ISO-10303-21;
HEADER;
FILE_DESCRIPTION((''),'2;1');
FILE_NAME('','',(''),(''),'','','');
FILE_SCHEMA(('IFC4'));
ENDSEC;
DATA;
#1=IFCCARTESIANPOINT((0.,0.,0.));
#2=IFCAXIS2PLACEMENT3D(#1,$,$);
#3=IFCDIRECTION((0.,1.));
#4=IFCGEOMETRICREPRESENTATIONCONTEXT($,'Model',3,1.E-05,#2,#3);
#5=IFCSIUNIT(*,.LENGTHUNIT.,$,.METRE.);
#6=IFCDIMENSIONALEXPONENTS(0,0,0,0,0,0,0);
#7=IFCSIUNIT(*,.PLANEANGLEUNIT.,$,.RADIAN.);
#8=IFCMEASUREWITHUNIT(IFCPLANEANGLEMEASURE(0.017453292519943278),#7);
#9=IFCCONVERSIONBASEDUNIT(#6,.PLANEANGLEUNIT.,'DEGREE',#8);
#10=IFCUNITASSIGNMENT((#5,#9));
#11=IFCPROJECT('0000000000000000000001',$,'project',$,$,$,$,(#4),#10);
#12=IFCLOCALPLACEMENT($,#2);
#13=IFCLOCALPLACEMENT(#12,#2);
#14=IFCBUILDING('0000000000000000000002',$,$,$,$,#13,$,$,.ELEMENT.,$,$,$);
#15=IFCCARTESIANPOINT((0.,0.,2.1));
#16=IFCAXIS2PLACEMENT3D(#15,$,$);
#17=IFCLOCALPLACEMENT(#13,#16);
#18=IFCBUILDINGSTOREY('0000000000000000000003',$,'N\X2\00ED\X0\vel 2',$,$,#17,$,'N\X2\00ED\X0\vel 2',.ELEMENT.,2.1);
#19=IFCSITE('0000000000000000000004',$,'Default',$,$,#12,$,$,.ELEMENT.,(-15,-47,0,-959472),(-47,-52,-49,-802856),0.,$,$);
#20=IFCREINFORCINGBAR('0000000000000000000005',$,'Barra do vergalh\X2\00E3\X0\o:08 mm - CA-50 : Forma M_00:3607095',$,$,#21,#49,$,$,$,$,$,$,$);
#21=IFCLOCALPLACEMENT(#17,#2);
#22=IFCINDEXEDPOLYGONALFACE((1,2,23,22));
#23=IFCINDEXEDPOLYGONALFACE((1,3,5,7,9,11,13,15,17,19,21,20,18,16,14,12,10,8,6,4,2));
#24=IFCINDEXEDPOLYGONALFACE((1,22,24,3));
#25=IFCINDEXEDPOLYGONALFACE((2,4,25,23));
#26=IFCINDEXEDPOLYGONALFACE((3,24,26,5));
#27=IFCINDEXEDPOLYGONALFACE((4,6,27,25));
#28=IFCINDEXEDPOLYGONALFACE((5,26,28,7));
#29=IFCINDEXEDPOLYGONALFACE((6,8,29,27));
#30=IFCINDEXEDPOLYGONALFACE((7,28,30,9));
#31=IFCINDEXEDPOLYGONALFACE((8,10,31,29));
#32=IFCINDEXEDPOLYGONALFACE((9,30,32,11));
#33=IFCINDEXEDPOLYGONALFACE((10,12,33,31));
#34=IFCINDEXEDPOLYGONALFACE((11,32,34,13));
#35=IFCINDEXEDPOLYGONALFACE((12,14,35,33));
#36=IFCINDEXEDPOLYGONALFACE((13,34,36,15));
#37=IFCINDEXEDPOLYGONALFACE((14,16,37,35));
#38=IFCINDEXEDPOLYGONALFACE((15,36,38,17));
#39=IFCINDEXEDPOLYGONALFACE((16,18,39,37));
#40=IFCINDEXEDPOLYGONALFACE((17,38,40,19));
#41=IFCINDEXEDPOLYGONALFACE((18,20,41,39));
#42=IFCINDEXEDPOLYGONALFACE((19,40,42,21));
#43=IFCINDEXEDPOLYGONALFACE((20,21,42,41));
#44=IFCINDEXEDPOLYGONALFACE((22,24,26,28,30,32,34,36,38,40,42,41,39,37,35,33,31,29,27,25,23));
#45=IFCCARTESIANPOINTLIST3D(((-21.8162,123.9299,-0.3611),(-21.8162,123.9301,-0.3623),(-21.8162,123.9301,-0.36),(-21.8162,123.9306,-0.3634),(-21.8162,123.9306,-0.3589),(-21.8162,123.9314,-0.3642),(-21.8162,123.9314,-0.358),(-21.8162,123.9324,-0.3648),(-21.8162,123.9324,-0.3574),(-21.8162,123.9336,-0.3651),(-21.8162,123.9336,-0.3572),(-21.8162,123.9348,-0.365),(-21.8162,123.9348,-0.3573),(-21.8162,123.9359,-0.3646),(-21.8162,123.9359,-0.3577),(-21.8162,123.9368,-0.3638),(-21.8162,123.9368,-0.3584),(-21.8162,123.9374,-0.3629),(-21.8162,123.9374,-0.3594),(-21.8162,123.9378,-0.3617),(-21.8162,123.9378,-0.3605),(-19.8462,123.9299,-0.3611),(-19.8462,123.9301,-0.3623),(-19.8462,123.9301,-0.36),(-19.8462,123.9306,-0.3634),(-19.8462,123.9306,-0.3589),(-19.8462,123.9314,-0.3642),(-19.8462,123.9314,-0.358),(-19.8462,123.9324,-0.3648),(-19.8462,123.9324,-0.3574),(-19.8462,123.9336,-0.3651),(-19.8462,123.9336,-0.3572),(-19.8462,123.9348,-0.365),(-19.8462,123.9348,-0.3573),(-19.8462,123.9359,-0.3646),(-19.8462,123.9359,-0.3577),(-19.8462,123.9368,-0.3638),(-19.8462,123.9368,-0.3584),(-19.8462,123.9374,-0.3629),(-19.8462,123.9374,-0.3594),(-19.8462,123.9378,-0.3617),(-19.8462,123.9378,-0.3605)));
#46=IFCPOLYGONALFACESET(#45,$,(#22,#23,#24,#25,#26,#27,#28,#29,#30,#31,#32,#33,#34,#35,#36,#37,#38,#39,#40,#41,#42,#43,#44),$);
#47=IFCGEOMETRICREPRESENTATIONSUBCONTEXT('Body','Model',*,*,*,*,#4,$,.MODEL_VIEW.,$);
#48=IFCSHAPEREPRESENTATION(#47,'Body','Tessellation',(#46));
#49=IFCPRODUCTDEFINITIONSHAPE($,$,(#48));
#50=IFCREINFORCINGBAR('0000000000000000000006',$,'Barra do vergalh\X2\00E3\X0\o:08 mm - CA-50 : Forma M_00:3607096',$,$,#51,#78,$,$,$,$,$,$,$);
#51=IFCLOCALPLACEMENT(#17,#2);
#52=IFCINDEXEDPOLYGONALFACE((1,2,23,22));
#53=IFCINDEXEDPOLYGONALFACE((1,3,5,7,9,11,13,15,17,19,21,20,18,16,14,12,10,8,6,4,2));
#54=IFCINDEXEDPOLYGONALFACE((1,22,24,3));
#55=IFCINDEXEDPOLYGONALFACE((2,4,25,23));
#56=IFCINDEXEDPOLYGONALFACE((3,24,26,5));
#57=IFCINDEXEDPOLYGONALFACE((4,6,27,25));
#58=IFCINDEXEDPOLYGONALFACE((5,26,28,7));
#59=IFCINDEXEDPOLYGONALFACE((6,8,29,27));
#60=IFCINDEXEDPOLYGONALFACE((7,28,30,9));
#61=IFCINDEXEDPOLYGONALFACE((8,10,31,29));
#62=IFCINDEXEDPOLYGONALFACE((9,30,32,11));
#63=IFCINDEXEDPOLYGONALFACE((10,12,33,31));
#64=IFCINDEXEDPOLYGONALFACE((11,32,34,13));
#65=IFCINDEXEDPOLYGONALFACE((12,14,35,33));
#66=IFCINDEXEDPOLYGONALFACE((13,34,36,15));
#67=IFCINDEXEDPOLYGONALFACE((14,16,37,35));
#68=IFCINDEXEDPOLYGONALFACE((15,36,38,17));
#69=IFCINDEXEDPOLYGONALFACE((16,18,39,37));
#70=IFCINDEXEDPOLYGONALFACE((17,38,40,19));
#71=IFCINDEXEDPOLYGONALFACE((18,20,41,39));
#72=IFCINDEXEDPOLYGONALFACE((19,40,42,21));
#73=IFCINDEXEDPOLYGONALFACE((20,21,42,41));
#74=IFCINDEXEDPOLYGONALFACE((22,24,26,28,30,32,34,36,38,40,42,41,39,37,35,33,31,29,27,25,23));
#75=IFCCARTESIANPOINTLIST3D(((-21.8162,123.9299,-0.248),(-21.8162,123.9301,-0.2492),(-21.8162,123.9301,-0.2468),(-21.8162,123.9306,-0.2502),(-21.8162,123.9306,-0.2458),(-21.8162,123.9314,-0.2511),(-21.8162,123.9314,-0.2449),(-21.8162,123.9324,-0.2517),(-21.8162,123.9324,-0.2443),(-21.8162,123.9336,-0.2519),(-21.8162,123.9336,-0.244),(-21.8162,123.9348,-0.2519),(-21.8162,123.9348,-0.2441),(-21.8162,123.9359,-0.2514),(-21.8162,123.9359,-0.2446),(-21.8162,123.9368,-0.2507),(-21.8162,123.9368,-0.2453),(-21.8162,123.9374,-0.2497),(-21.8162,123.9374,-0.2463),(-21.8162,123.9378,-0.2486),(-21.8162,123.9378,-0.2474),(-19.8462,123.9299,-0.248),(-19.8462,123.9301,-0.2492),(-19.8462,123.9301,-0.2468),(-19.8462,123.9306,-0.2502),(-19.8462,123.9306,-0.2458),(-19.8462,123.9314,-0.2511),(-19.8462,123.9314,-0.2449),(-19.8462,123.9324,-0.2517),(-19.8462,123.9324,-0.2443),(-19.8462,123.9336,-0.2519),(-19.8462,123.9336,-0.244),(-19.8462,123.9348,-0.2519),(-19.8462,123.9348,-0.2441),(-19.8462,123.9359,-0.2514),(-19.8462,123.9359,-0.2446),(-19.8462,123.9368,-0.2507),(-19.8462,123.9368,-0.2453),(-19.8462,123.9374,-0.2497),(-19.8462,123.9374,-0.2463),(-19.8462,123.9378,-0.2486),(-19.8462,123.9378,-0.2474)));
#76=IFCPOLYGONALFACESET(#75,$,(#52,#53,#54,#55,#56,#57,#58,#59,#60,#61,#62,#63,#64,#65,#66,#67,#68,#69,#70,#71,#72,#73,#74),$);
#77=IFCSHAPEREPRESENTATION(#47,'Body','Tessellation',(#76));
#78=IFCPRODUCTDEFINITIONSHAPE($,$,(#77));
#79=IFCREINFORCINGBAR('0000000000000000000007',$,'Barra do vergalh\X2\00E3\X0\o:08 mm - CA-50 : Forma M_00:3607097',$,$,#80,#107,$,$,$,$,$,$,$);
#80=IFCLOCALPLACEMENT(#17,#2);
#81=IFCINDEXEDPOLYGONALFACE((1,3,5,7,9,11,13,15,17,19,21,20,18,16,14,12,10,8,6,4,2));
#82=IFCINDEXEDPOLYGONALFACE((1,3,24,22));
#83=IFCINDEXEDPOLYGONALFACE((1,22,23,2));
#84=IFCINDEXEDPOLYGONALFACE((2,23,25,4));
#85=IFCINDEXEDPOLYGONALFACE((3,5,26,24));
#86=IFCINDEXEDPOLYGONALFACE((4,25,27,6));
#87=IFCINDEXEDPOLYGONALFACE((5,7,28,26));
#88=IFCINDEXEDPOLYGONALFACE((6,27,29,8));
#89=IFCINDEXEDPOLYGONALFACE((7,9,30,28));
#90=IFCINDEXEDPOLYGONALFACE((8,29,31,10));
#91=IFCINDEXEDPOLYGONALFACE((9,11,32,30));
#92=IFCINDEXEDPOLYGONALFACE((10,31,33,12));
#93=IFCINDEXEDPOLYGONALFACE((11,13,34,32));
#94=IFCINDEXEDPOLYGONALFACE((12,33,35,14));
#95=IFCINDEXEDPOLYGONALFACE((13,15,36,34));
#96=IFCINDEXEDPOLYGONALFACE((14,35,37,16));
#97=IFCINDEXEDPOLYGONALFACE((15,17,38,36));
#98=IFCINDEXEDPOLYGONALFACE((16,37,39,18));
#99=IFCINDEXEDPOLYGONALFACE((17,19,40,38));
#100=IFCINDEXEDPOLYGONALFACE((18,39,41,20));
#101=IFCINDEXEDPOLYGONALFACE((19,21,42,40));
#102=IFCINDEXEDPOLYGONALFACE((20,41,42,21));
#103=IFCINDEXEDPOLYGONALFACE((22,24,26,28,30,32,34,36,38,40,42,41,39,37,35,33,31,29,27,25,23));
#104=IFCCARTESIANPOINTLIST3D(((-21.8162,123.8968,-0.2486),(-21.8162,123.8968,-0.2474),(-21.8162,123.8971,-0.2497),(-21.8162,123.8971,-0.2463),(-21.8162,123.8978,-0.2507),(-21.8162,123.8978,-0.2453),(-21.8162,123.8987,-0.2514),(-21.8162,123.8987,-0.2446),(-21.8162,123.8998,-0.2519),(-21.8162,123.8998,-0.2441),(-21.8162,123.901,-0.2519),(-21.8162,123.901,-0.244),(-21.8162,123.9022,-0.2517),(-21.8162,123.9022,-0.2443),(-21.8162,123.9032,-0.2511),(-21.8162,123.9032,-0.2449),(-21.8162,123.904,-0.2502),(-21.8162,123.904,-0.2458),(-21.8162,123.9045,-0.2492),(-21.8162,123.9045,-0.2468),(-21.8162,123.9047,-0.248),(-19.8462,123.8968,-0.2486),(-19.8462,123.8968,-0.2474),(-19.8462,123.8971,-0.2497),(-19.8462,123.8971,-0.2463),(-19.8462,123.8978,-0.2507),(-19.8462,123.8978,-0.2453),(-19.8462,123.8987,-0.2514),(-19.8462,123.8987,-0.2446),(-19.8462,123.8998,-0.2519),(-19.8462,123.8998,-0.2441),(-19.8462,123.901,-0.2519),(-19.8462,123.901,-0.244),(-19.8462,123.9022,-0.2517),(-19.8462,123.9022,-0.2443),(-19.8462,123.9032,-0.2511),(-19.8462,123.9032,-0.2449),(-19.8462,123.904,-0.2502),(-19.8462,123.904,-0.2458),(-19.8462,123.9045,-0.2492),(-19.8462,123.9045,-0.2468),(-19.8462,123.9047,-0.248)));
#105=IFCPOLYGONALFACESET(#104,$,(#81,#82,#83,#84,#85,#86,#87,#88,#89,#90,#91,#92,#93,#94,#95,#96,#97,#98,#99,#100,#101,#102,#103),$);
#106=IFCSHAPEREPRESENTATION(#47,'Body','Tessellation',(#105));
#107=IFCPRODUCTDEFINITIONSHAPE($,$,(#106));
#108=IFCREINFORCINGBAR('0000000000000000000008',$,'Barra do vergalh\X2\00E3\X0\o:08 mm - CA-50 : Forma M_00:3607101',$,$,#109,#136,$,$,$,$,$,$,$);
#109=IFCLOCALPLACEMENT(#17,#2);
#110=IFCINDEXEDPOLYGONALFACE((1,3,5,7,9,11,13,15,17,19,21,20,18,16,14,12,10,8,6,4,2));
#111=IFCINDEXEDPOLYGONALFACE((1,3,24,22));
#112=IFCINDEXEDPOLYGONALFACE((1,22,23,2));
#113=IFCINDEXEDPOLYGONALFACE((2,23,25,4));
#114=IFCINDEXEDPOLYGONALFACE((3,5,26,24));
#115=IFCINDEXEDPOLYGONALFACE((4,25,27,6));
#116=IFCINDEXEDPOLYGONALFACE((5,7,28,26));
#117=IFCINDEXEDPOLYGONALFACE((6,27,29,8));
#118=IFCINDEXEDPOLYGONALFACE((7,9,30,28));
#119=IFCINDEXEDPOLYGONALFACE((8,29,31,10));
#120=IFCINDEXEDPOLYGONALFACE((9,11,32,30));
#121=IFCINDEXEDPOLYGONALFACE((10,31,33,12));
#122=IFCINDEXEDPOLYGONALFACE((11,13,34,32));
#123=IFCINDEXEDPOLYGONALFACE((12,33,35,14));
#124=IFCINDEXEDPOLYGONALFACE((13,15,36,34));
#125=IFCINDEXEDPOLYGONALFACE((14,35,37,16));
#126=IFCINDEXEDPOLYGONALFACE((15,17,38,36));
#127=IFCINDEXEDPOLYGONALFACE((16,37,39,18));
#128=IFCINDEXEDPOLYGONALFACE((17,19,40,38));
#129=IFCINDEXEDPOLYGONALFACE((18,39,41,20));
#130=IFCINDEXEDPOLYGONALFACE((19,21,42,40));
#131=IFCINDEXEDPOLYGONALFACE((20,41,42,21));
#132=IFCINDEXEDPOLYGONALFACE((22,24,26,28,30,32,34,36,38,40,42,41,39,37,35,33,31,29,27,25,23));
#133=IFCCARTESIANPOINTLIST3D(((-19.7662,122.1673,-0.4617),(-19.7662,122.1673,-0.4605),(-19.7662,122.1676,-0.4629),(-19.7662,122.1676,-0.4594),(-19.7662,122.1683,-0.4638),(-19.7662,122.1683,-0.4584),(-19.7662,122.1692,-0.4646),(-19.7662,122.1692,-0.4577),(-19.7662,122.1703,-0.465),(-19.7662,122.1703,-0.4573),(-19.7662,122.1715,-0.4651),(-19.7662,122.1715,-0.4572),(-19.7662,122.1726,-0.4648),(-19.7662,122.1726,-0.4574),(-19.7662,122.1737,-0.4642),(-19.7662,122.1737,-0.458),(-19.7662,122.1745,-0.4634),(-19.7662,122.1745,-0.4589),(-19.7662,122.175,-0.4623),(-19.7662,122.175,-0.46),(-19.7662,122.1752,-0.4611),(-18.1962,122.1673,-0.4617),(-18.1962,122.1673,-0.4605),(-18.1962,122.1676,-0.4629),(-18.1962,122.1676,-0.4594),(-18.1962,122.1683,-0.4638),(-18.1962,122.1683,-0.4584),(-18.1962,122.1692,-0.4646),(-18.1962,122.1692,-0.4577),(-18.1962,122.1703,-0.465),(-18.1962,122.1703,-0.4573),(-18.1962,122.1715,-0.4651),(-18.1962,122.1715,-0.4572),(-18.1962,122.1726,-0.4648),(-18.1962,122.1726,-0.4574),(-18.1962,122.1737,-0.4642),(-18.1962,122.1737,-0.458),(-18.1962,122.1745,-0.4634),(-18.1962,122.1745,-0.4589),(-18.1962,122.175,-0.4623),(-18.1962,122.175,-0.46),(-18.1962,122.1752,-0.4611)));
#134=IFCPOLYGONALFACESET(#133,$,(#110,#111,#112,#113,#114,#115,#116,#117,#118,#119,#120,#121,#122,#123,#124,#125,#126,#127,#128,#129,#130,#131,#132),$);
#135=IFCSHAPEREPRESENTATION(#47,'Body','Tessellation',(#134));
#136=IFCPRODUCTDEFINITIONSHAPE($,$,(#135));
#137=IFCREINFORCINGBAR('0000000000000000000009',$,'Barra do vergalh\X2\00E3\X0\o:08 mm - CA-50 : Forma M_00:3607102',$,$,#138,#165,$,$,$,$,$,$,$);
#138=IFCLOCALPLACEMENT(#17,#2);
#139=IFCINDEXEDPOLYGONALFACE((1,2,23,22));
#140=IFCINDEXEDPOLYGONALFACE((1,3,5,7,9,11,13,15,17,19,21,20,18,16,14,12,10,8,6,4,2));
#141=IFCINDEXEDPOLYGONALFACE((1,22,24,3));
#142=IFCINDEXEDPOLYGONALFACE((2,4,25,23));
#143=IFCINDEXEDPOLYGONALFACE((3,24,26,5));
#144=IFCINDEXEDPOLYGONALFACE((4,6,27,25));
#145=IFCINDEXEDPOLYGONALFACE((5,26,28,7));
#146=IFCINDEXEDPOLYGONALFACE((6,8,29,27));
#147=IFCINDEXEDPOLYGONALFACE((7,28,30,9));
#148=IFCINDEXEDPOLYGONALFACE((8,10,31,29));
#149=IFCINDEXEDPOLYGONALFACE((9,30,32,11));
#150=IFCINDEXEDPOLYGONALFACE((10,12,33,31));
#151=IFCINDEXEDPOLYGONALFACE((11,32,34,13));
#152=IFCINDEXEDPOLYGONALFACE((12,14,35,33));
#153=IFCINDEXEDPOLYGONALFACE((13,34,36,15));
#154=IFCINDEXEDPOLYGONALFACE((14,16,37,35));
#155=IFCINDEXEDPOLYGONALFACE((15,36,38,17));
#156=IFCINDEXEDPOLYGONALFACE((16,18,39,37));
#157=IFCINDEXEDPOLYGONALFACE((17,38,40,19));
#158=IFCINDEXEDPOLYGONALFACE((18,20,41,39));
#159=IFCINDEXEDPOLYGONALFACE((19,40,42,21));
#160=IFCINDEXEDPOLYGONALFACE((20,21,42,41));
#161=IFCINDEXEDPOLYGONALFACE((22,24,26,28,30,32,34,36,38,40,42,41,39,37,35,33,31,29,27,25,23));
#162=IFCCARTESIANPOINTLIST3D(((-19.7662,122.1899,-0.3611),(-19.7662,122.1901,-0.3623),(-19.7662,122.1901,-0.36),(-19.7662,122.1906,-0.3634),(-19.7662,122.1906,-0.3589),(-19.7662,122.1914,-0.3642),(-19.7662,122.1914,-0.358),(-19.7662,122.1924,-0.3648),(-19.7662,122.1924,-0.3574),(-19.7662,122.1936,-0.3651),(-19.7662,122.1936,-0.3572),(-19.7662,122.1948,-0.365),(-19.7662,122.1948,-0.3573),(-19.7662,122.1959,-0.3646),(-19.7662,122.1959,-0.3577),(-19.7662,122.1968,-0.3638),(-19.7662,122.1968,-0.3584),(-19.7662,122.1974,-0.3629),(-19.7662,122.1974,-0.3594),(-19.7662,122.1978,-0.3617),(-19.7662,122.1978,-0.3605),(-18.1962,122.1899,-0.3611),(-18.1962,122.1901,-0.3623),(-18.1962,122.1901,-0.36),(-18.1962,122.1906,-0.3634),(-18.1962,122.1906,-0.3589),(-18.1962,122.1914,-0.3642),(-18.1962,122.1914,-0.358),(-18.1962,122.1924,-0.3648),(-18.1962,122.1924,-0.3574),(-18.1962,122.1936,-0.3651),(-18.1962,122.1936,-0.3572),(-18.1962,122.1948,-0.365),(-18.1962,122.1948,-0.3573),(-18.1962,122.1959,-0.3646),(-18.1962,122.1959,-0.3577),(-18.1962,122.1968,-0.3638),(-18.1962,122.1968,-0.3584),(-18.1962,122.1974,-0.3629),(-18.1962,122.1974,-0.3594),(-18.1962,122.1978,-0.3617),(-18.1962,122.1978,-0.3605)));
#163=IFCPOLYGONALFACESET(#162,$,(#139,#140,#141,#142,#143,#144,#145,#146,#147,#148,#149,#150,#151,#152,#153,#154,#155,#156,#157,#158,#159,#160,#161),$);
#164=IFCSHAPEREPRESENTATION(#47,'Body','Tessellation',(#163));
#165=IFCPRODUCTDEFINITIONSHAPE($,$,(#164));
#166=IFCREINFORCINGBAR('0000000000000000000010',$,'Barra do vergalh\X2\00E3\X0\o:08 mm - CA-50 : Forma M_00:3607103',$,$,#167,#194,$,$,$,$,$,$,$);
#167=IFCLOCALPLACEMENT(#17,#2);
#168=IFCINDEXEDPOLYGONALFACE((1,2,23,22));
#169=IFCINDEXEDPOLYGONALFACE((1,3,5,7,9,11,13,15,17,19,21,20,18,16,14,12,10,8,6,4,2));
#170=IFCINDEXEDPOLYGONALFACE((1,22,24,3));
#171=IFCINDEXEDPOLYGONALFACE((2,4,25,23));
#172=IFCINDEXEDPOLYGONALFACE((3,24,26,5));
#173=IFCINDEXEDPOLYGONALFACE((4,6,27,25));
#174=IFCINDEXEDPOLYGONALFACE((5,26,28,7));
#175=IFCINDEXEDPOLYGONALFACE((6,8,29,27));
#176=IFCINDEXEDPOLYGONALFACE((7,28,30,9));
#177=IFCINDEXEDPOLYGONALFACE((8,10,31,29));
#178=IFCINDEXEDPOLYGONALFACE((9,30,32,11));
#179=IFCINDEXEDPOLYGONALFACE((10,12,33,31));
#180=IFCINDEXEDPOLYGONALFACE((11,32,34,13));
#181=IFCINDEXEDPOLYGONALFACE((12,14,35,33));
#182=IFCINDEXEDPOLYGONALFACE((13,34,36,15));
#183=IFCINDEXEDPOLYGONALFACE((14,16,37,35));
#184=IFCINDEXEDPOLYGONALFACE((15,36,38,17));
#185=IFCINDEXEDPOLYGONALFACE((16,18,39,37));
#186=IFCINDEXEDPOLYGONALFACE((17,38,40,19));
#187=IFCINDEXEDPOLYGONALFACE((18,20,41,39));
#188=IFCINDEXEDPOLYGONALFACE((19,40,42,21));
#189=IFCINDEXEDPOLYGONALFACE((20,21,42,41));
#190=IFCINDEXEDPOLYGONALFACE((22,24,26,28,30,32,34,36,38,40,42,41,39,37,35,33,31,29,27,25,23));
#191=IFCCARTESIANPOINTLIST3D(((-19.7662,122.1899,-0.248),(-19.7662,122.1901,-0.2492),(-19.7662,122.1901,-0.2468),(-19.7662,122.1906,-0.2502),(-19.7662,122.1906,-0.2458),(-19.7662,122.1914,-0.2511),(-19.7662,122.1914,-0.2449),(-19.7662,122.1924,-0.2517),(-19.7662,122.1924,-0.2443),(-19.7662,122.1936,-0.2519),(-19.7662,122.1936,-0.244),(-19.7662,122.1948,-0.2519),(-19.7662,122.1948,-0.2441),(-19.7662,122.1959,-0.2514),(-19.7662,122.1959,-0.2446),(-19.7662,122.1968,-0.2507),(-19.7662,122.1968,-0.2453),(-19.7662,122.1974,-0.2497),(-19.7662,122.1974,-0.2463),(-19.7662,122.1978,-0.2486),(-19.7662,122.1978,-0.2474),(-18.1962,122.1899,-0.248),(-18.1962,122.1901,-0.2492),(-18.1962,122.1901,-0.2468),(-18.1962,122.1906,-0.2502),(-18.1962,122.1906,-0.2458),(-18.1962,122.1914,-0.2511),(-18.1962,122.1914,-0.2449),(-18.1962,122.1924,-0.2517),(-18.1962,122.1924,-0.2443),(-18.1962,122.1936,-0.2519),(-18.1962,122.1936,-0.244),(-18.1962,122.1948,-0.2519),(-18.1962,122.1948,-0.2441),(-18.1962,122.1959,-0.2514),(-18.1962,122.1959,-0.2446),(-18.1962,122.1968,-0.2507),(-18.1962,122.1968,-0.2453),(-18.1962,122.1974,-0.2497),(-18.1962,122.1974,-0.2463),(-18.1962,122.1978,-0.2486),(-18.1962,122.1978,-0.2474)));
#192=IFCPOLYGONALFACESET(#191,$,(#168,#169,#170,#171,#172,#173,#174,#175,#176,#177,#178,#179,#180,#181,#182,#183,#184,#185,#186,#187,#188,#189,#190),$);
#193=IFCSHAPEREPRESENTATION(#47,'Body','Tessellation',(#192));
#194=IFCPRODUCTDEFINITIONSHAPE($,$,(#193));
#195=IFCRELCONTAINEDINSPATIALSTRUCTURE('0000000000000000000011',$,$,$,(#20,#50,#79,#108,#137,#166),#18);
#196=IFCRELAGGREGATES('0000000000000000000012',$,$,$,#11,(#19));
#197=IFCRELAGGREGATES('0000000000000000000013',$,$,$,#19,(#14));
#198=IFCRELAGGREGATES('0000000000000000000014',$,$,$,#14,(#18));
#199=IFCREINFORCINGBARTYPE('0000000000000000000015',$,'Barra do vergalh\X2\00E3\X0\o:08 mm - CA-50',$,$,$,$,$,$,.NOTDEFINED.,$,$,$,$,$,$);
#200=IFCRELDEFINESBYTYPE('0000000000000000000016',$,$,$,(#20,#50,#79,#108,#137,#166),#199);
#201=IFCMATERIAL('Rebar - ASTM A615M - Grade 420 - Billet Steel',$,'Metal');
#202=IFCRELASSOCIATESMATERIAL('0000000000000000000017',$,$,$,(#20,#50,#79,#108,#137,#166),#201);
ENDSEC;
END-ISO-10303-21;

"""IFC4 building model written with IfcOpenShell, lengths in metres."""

from ifc_helpers import new_model, entity, si_unit, converted_unit, direction, frame, origin, place, context, subcontext, project, spatial, material, type_object, element, save


model = new_model("IFC4")

# Units and contexts
model_context = context("Model", 3, precision=1e-05, world=origin(), true_north=direction((0.0, 1.0)))
body_context = subcontext(model_context, "Body", "Model", "MODEL_VIEW")
ifc_project = project(units=[si_unit("LENGTHUNIT", "METRE"), converted_unit("PLANEANGLEUNIT", "DEGREE", entity("IfcPlaneAngleMeasure", 0.017453292519943278), si_unit("PLANEANGLEUNIT", "RADIAN"), dimensions=[0, 0, 0, 0, 0, 0, 0])], contexts=[model_context])

# Site, building, storey
site_placement = place(None, origin())
site = spatial("IfcSite", under=ifc_project, at=site_placement, Name="Default", CompositionType="ELEMENT", RefLatitude=(-15, -47, 0, -959472), RefLongitude=(-47, -52, -49, -802856), RefElevation=0.0)
building_placement = place(site_placement, origin())
building = spatial("IfcBuilding", under=site, at=building_placement, CompositionType="ELEMENT")
storey_placement = place(building_placement, frame((0.0, 0.0, 2.1)))
storey = spatial("IfcBuildingStorey", under=building, at=storey_placement, Name="Nível 2", LongName="Nível 2", CompositionType="ELEMENT", Elevation=2.1)

# Reinforcing bars
ifc_material_1 = material(Name="Rebar - ASTM A615M - Grade 420 - Billet Steel", Category="Metal")
reinforcing_bar_type_1 = type_object("IfcReinforcingBarType", Name="Barra do vergalhão:08 mm - CA-50", PredefinedType="NOTDEFINED")
reinforcing_bar_1_placement = place(storey_placement, origin())
element("IfcReinforcingBar", 1, at=reinforcing_bar_1_placement, inside=storey, type_object=reinforcing_bar_type_1, material=ifc_material_1, Name="Barra do vergalhão:08 mm - CA-50 : Forma M_00:3607095", context=body_context, shape_type="AdvancedSweptSolid", body=[
    entity("IfcSweptDiskSolid", entity("IfcIndexedPolyCurve", entity("IfcCartesianPointList3D", [[21.8162, -123.9339, 0.3611], [19.8462, -123.9339, 0.3611]]), None, False), 0.004, None, 0.0, 1.0),
])
reinforcing_bar_2_placement = place(storey_placement, origin())
element("IfcReinforcingBar", 2, at=reinforcing_bar_2_placement, inside=storey, type_object=reinforcing_bar_type_1, material=ifc_material_1, Name="Barra do vergalhão:08 mm - CA-50 : Forma M_00:3607096", context=body_context, shape_type="AdvancedSweptSolid", body=[
    entity("IfcSweptDiskSolid", entity("IfcIndexedPolyCurve", entity("IfcCartesianPointList3D", [[21.8162, -123.9339, 0.248], [19.8462, -123.9339, 0.248]]), None, False), 0.004, None, 0.0, 1.0),
])
reinforcing_bar_3_placement = place(storey_placement, origin())
element("IfcReinforcingBar", 3, at=reinforcing_bar_3_placement, inside=storey, type_object=reinforcing_bar_type_1, material=ifc_material_1, Name="Barra do vergalhão:08 mm - CA-50 : Forma M_00:3607097", context=body_context, shape_type="AdvancedSweptSolid", body=[
    entity("IfcSweptDiskSolid", entity("IfcIndexedPolyCurve", entity("IfcCartesianPointList3D", [[19.8462, -123.9007, 0.248], [21.8162, -123.9007, 0.248]]), None, False), 0.004, None, 0.0, 1.0),
])
reinforcing_bar_4_placement = place(storey_placement, origin())
element("IfcReinforcingBar", 4, at=reinforcing_bar_4_placement, inside=storey, type_object=reinforcing_bar_type_1, material=ifc_material_1, Name="Barra do vergalhão:08 mm - CA-50 : Forma M_00:3607101", context=body_context, shape_type="AdvancedSweptSolid", body=[
    entity("IfcSweptDiskSolid", entity("IfcIndexedPolyCurve", entity("IfcCartesianPointList3D", [[18.1962, -122.1712, 0.4611], [19.7662, -122.1712, 0.4611]]), None, False), 0.004, None, 0.0, 1.0),
])
reinforcing_bar_5_placement = place(storey_placement, origin())
element("IfcReinforcingBar", 5, at=reinforcing_bar_5_placement, inside=storey, type_object=reinforcing_bar_type_1, material=ifc_material_1, Name="Barra do vergalhão:08 mm - CA-50 : Forma M_00:3607102", context=body_context, shape_type="AdvancedSweptSolid", body=[
    entity("IfcSweptDiskSolid", entity("IfcIndexedPolyCurve", entity("IfcCartesianPointList3D", [[19.7662, -122.1939, 0.3611], [18.1962, -122.1939, 0.3611]]), None, False), 0.004, None, 0.0, 1.0),
])
reinforcing_bar_6_placement = place(storey_placement, origin())
element("IfcReinforcingBar", 6, at=reinforcing_bar_6_placement, inside=storey, type_object=reinforcing_bar_type_1, material=ifc_material_1, Name="Barra do vergalhão:08 mm - CA-50 : Forma M_00:3607103", context=body_context, shape_type="AdvancedSweptSolid", body=[
    entity("IfcSweptDiskSolid", entity("IfcIndexedPolyCurve", entity("IfcCartesianPointList3D", [[19.7662, -122.1939, 0.248], [18.1962, -122.1939, 0.248]]), None, False), 0.004, None, 0.0, 1.0),
])

save(model, "model.ifc")
